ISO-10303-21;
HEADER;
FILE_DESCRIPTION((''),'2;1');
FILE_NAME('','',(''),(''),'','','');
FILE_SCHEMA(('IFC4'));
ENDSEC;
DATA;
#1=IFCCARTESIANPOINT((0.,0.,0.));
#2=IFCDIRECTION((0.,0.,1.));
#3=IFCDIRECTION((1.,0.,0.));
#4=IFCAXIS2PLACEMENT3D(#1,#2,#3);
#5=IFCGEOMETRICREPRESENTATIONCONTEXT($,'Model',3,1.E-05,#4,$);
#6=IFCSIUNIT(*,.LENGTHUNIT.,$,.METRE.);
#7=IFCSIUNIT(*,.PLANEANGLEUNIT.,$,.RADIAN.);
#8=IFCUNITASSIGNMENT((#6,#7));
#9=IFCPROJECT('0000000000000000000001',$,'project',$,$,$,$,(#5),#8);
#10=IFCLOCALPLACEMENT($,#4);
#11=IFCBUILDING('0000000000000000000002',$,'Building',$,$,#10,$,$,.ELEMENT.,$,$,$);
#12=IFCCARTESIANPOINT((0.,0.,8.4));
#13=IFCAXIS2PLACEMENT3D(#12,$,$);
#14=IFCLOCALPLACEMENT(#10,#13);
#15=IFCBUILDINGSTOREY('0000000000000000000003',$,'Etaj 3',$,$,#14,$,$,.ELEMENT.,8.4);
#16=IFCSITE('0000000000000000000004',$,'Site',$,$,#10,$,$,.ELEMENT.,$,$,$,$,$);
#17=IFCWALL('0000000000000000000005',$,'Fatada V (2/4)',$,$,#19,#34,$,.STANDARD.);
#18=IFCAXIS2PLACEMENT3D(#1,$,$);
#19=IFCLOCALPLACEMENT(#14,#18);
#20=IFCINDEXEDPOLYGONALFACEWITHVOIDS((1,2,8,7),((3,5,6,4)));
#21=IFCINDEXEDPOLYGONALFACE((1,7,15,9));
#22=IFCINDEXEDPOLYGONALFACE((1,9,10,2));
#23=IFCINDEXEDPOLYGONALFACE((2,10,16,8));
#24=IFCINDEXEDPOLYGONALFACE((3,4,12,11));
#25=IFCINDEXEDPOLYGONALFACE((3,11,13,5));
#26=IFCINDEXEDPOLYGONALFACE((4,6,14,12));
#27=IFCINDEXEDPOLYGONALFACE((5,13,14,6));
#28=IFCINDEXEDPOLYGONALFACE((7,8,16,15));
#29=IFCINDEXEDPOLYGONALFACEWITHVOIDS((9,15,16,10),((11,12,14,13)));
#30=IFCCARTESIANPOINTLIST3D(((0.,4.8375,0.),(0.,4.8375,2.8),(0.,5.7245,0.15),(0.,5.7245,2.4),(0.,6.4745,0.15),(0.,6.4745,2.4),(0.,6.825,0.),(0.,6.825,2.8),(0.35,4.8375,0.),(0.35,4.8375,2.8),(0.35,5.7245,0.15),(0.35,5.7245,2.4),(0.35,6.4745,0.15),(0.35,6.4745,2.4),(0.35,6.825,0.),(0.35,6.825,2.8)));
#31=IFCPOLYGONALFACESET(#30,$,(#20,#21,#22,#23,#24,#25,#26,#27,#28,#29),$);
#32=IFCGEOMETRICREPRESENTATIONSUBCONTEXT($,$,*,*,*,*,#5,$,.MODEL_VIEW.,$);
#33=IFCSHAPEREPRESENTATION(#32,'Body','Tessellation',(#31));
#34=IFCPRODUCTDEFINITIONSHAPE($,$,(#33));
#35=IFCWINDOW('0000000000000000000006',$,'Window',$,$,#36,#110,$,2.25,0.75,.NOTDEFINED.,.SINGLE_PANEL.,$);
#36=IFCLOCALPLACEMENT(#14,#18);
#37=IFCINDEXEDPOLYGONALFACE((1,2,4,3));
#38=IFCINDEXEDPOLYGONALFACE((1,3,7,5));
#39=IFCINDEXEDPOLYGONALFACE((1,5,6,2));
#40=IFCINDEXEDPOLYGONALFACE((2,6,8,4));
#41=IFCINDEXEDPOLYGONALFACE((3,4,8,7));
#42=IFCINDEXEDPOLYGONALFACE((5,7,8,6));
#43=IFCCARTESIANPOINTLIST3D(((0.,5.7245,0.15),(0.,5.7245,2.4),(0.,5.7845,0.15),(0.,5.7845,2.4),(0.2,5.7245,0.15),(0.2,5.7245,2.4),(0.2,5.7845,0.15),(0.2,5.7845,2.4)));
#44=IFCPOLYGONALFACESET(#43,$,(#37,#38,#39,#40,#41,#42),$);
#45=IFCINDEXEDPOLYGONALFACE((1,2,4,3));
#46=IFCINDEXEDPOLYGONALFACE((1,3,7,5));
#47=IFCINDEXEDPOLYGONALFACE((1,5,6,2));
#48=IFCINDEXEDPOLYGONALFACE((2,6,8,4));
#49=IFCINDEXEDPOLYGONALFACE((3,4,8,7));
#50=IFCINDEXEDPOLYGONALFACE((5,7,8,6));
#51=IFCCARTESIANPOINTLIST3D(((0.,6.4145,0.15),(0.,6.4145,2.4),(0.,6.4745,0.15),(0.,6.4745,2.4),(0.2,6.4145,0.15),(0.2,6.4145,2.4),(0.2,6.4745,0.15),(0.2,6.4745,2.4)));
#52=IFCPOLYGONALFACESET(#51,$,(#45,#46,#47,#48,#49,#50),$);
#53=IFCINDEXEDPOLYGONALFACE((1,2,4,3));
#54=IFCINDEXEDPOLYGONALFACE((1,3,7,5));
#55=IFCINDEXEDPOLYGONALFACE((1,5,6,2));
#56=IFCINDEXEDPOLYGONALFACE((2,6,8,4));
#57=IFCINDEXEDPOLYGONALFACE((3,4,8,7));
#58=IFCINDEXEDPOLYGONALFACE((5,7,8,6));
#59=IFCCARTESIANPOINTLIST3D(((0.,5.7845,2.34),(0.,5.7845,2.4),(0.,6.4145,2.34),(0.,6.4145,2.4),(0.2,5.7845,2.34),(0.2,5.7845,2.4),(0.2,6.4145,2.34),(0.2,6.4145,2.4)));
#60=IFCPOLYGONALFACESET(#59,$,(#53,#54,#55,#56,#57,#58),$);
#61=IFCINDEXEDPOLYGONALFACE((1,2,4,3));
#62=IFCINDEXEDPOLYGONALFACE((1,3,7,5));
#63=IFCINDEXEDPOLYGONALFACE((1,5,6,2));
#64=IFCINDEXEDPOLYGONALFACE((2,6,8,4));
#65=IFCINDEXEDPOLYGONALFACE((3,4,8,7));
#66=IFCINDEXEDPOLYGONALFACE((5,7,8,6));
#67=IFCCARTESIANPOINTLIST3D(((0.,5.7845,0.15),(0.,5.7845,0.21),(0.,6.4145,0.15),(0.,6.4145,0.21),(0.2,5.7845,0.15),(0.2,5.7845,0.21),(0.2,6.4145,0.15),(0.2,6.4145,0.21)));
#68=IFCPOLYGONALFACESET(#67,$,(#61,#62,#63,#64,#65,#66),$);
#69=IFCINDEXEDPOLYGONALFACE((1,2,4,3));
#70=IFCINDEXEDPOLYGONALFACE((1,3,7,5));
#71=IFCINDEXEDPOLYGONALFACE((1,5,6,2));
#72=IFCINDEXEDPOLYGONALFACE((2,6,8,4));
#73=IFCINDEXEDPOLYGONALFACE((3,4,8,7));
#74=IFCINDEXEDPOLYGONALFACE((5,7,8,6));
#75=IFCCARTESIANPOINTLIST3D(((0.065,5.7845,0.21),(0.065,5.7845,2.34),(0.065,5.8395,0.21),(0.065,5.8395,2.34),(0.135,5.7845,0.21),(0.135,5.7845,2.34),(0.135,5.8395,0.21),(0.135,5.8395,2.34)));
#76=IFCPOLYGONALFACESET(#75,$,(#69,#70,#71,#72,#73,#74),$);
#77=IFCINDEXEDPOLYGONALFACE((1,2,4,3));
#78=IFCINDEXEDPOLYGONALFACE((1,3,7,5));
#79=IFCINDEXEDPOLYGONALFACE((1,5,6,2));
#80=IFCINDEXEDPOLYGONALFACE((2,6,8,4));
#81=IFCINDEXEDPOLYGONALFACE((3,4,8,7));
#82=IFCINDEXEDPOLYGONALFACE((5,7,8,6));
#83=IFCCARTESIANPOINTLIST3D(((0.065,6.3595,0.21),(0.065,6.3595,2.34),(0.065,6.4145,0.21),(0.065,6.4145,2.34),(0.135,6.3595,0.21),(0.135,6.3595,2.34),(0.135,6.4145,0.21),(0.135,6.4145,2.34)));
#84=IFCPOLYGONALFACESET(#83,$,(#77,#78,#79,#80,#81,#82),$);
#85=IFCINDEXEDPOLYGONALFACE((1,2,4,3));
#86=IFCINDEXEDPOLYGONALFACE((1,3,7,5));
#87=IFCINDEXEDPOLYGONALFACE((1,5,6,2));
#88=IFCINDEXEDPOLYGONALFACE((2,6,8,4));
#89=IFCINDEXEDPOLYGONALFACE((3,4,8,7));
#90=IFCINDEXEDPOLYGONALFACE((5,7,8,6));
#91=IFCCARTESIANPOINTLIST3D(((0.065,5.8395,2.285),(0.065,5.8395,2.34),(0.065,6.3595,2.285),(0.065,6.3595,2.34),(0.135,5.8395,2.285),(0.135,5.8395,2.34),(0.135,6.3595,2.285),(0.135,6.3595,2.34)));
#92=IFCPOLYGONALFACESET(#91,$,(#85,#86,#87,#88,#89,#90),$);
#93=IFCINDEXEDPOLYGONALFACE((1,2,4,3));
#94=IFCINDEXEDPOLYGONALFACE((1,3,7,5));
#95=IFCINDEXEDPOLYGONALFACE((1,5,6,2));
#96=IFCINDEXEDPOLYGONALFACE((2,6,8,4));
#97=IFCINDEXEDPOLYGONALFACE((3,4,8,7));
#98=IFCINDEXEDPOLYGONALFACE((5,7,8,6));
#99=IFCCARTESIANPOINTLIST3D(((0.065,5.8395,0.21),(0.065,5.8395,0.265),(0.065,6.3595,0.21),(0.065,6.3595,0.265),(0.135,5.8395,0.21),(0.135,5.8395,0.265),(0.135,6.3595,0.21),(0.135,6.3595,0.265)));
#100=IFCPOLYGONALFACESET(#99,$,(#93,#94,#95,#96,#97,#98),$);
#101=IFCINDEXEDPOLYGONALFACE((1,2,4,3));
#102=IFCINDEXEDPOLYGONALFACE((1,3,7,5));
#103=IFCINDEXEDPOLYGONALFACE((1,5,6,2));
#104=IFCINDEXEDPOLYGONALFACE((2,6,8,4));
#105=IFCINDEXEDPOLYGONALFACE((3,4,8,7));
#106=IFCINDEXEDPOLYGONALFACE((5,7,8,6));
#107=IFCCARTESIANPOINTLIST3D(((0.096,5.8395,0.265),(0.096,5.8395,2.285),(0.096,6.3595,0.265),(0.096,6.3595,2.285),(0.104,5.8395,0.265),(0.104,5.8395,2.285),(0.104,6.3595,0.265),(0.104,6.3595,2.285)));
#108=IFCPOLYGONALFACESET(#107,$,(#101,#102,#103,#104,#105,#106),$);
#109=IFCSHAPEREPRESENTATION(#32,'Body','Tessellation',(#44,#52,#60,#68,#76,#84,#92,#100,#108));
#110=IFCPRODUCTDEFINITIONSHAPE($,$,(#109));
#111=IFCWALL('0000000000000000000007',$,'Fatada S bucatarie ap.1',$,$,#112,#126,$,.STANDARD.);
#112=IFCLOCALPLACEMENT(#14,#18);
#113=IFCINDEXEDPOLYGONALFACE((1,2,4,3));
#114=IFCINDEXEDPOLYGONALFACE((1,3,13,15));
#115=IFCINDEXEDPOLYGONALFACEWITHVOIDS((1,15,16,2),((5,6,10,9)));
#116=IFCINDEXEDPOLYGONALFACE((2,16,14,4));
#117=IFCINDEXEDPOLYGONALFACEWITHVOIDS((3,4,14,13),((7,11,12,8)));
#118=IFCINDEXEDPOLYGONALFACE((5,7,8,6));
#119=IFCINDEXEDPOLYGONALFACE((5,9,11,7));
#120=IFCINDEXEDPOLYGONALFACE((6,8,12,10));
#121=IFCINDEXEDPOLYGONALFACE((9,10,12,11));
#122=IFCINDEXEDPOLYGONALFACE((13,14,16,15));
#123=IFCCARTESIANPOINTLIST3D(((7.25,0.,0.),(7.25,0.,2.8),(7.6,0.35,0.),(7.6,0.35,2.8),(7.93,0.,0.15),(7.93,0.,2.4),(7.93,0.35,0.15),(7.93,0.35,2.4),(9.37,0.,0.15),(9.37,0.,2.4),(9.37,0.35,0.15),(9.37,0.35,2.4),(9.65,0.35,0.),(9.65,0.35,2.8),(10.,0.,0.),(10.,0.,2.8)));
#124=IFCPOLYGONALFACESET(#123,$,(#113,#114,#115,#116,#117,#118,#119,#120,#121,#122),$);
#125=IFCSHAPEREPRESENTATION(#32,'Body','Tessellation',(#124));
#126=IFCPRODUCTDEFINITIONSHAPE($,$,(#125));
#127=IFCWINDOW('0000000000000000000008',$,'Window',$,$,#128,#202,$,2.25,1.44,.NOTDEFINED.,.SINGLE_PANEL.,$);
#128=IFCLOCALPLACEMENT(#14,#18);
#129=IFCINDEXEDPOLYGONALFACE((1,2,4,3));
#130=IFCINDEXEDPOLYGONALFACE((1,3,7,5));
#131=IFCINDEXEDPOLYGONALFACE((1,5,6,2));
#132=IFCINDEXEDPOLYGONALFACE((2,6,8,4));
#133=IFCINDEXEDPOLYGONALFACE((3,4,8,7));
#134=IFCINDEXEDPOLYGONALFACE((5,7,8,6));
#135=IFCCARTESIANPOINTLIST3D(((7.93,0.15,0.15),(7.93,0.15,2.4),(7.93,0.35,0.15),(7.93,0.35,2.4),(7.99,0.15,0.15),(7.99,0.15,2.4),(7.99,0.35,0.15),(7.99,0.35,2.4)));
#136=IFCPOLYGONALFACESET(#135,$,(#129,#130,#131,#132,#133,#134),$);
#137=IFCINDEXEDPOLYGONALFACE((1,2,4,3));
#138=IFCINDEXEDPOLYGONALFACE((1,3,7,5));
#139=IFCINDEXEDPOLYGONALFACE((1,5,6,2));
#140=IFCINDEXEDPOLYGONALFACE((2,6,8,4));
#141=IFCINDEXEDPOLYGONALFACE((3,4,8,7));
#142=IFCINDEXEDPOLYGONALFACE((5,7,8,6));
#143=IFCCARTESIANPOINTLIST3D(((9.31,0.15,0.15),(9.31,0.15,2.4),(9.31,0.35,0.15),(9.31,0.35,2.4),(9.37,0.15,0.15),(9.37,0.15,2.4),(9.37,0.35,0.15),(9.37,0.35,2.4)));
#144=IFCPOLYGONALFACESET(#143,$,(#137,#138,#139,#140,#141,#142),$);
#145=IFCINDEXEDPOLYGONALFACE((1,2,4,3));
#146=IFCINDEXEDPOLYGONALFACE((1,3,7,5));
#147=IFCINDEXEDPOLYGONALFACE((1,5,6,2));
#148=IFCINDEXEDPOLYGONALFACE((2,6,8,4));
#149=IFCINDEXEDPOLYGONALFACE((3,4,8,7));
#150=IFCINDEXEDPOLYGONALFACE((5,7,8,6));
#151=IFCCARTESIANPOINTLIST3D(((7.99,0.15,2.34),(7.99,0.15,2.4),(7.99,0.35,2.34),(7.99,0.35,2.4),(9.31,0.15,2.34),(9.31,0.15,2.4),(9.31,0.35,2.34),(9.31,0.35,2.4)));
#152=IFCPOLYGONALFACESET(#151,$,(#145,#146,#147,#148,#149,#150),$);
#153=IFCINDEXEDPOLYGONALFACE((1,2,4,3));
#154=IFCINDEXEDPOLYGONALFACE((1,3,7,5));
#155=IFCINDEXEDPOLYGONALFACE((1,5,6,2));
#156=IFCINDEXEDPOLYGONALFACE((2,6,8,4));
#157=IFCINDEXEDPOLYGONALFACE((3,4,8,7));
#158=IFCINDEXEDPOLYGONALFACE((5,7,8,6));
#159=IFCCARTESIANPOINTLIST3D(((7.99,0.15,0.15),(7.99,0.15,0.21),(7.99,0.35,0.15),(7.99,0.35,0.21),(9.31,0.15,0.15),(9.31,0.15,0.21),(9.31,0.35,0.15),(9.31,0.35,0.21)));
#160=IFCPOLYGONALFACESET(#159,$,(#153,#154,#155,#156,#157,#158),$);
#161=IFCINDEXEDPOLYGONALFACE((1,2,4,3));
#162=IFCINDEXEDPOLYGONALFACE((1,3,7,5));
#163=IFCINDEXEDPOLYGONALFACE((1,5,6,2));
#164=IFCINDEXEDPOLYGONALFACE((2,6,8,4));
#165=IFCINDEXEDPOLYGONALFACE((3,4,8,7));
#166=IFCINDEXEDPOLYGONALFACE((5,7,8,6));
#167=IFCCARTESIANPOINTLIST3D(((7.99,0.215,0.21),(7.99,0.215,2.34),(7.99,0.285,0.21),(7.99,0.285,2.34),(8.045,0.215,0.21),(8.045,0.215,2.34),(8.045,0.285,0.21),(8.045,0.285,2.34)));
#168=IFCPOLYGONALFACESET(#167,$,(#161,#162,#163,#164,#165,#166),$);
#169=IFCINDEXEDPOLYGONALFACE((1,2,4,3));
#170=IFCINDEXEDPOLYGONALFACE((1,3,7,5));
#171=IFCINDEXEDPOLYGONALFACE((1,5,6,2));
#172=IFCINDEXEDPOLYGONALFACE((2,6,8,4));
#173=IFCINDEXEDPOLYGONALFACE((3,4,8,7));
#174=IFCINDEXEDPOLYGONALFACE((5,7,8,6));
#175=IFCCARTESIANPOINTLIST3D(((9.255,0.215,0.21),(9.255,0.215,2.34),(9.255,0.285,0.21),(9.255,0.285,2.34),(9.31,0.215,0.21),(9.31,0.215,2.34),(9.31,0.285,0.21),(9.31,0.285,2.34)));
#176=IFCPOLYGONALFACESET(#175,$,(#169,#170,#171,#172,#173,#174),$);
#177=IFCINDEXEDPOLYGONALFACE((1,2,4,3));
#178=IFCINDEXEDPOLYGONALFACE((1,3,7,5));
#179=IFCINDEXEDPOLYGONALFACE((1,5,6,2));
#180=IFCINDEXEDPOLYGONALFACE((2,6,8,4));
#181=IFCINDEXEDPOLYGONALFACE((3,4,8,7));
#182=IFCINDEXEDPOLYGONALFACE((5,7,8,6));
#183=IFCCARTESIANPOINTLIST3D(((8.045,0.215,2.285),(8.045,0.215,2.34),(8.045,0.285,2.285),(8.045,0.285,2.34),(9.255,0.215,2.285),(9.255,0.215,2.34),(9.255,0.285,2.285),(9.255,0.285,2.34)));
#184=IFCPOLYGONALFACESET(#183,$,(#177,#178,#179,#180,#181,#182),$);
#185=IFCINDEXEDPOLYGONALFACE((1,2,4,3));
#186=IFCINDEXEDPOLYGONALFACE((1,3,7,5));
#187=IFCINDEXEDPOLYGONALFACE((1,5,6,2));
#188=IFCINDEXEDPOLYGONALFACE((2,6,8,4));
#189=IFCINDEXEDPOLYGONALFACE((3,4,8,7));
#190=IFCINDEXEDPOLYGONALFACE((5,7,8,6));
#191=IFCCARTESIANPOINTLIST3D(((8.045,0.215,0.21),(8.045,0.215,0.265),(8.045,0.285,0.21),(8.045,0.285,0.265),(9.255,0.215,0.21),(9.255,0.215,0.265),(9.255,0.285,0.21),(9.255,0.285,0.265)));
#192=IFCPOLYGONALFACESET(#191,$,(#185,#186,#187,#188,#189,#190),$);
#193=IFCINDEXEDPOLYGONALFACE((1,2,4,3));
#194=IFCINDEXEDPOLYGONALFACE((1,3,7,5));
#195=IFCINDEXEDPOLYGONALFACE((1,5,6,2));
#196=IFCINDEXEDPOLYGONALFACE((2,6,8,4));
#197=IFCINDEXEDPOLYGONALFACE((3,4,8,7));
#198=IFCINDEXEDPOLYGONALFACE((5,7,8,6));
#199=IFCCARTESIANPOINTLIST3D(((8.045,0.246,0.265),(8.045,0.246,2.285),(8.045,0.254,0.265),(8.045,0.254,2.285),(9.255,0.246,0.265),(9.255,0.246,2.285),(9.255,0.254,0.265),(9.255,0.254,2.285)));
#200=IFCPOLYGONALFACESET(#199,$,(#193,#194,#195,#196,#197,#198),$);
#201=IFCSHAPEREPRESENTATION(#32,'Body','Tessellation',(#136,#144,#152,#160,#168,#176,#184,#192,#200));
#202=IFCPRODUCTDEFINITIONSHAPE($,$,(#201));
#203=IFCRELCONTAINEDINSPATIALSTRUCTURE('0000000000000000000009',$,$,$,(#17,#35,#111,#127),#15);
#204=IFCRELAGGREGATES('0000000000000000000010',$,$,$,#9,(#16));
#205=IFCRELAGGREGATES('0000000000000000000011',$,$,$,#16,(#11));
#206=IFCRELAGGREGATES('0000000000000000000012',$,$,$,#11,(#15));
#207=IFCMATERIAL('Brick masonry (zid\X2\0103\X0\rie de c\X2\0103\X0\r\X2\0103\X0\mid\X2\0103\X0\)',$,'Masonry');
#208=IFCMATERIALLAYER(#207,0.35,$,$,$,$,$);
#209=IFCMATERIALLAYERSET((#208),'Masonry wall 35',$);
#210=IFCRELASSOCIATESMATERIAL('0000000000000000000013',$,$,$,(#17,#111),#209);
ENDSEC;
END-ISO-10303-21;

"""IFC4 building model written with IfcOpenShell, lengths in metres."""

from ifc_helpers import new_model, si_unit, frame, frame_2d, origin, origin_with_axes, origin_2d, place, context, subcontext, project, spatial, rectangle, extrude, clip, halfspace, material, layer, layer_set, layer_usage, element, fill, save


model = new_model("IFC4")

# Units and contexts
model_context = context("Model", 3, precision=1e-05, world=origin_with_axes())
sub_context = subcontext(model_context, None, None, "MODEL_VIEW")
ifc_project = project(units=[si_unit("LENGTHUNIT", "METRE"), si_unit("PLANEANGLEUNIT", "RADIAN")], contexts=[model_context])

# Site, building, storey
placement = place(None, origin_with_axes())
site = spatial("IfcSite", under=ifc_project, at=placement, Name="Site", CompositionType="ELEMENT")
building = spatial("IfcBuilding", under=site, at=placement, Name="Building", CompositionType="ELEMENT")
storey_placement = place(placement, frame((0.0, 0.0, 8.4)))
storey = spatial("IfcBuildingStorey", under=building, at=storey_placement, Name="Etaj 3", CompositionType="ELEMENT", Elevation=8.4)

# Walls, openings, windows
ifc_material_1 = material(Name="Brick masonry (zidărie de cărămidă)", Category="Masonry")
ifc_layer_1 = layer(ifc_material_1, 0.35)
ifc_layer_set_1 = layer_set([ifc_layer_1], Name="Masonry wall 35")
ifc_layer_usage_1 = layer_usage(ifc_layer_set_1, "AXIS2", "POSITIVE", -0.175)
wall_1_placement = place(storey_placement, frame((0.175, 4.8375, 0.0), x_axis=(0.0, 1.0, 0.0)))
wall_1 = element("IfcWall", 1, at=wall_1_placement, inside=storey, material=ifc_layer_usage_1, Name="Fatada V (2/4)", PredefinedType="STANDARD", context=sub_context, shape_type="SweptSolid", body=[
    extrude(rectangle(XDim=1.9875, YDim=0.35, at=frame_2d((0.9937, 0.0))), origin(), (0.0, 0.0, 1.0), 2.8),
])
opening_1_placement = place(wall_1_placement, frame((1.262, 0.225, 0.15), z_axis=(0.0, -1.0, 0.0), x_axis=(1.0, 0.0, 0.0)))
opening_1 = element("IfcOpeningElement", 2, at=opening_1_placement, cuts=wall_1, PredefinedType="OPENING", context=sub_context, shape_type="SweptSolid", body=[
    extrude(rectangle(XDim=0.75, YDim=2.25, at=frame_2d((0.0, 1.125))), origin(), (0.0, 0.0, 1.0), 0.45),
])
window_1_placement = place(wall_1_placement, frame((1.262, 0.175, 0.15), z_axis=(0.0, -1.0, 0.0), x_axis=(1.0, 0.0, 0.0)))
window_1 = element("IfcWindow", 3, at=window_1_placement, inside=storey, Name="Window", OverallHeight=2.25, OverallWidth=0.75, PartitioningType="SINGLE_PANEL", PredefinedType="NOTDEFINED", context=sub_context, shape_type="SweptSolid", body=[
    extrude(rectangle(XDim=0.06, YDim=2.25, at=origin_2d()), frame((-0.345, 1.125, 0.0)), (0.0, 0.0, 1.0), 0.2),
    extrude(rectangle(XDim=0.06, YDim=2.25, at=origin_2d()), frame((0.345, 1.125, 0.0)), (0.0, 0.0, 1.0), 0.2),
    extrude(rectangle(XDim=0.63, YDim=0.06, at=origin_2d()), frame((0.0, 2.22, 0.0)), (0.0, 0.0, 1.0), 0.2),
    extrude(rectangle(XDim=0.63, YDim=0.06, at=origin_2d()), frame((0.0, 0.03, 0.0)), (0.0, 0.0, 1.0), 0.2),
    extrude(rectangle(XDim=0.055, YDim=2.13, at=origin_2d()), frame((-0.2875, 1.125, 0.065)), (0.0, 0.0, 1.0), 0.07),
    extrude(rectangle(XDim=0.055, YDim=2.13, at=origin_2d()), frame((0.2875, 1.125, 0.065)), (0.0, 0.0, 1.0), 0.07),
    extrude(rectangle(XDim=0.52, YDim=0.055, at=origin_2d()), frame((0.0, 2.1625, 0.065)), (0.0, 0.0, 1.0), 0.07),
    extrude(rectangle(XDim=0.52, YDim=0.055, at=origin_2d()), frame((0.0, 0.0875, 0.065)), (0.0, 0.0, 1.0), 0.07),
    extrude(rectangle(XDim=0.52, YDim=2.02, at=origin_2d()), frame((0.0, 1.125, 0.096)), (0.0, 0.0, 1.0), 0.008),
])
fill(opening_1, window_1)
wall_2_placement = place(storey_placement, frame((7.25, 0.175, 0.0), x_axis=(1.0, 0.0, 0.0)))
wall_2 = element("IfcWall", 4, at=wall_2_placement, inside=storey, material=ifc_layer_usage_1, Name="Fatada S bucatarie ap.1", PredefinedType="STANDARD", context=sub_context, shape_type="CSG", body=[
    clip(clip(extrude(rectangle(XDim=2.75, YDim=0.35, at=frame_2d((1.375, 0.0))), origin(), (0.0, 0.0, 1.0), 2.8), halfspace(frame((0.175, 0.0, 0.0), z_axis=(-0.707107, 0.707107, 0.0)), False)), halfspace(frame((2.575, 0.0, 0.0), z_axis=(0.707107, 0.707107, 0.0)), False)),
])
opening_2_placement = place(wall_2_placement, frame((1.4, 0.225, 0.15), z_axis=(0.0, -1.0, 0.0), x_axis=(1.0, 0.0, 0.0)))
opening_2 = element("IfcOpeningElement", 5, at=opening_2_placement, cuts=wall_2, PredefinedType="OPENING", context=sub_context, shape_type="SweptSolid", body=[
    extrude(rectangle(XDim=1.44, YDim=2.25, at=frame_2d((0.0, 1.125))), origin(), (0.0, 0.0, 1.0), 0.45),
])
window_2_placement = place(wall_2_placement, frame((1.4, 0.175, 0.15), z_axis=(0.0, -1.0, 0.0), x_axis=(1.0, 0.0, 0.0)))
window_2 = element("IfcWindow", 6, at=window_2_placement, inside=storey, Name="Window", OverallHeight=2.25, OverallWidth=1.44, PartitioningType="SINGLE_PANEL", PredefinedType="NOTDEFINED", context=sub_context, shape_type="SweptSolid", body=[
    extrude(rectangle(XDim=0.06, YDim=2.25, at=origin_2d()), frame((-0.69, 1.125, 0.0)), (0.0, 0.0, 1.0), 0.2),
    extrude(rectangle(XDim=0.06, YDim=2.25, at=origin_2d()), frame((0.69, 1.125, 0.0)), (0.0, 0.0, 1.0), 0.2),
    extrude(rectangle(XDim=1.32, YDim=0.06, at=origin_2d()), frame((0.0, 2.22, 0.0)), (0.0, 0.0, 1.0), 0.2),
    extrude(rectangle(XDim=1.32, YDim=0.06, at=origin_2d()), frame((0.0, 0.03, 0.0)), (0.0, 0.0, 1.0), 0.2),
    extrude(rectangle(XDim=0.055, YDim=2.13, at=origin_2d()), frame((-0.6325, 1.125, 0.065)), (0.0, 0.0, 1.0), 0.07),
    extrude(rectangle(XDim=0.055, YDim=2.13, at=origin_2d()), frame((0.6325, 1.125, 0.065)), (0.0, 0.0, 1.0), 0.07),
    extrude(rectangle(XDim=1.21, YDim=0.055, at=origin_2d()), frame((0.0, 2.1625, 0.065)), (0.0, 0.0, 1.0), 0.07),
    extrude(rectangle(XDim=1.21, YDim=0.055, at=origin_2d()), frame((0.0, 0.0875, 0.065)), (0.0, 0.0, 1.0), 0.07),
    extrude(rectangle(XDim=1.21, YDim=2.02, at=origin_2d()), frame((0.0, 1.125, 0.096)), (0.0, 0.0, 1.0), 0.008),
])
fill(opening_2, window_2)

save(model, "model.ifc")
